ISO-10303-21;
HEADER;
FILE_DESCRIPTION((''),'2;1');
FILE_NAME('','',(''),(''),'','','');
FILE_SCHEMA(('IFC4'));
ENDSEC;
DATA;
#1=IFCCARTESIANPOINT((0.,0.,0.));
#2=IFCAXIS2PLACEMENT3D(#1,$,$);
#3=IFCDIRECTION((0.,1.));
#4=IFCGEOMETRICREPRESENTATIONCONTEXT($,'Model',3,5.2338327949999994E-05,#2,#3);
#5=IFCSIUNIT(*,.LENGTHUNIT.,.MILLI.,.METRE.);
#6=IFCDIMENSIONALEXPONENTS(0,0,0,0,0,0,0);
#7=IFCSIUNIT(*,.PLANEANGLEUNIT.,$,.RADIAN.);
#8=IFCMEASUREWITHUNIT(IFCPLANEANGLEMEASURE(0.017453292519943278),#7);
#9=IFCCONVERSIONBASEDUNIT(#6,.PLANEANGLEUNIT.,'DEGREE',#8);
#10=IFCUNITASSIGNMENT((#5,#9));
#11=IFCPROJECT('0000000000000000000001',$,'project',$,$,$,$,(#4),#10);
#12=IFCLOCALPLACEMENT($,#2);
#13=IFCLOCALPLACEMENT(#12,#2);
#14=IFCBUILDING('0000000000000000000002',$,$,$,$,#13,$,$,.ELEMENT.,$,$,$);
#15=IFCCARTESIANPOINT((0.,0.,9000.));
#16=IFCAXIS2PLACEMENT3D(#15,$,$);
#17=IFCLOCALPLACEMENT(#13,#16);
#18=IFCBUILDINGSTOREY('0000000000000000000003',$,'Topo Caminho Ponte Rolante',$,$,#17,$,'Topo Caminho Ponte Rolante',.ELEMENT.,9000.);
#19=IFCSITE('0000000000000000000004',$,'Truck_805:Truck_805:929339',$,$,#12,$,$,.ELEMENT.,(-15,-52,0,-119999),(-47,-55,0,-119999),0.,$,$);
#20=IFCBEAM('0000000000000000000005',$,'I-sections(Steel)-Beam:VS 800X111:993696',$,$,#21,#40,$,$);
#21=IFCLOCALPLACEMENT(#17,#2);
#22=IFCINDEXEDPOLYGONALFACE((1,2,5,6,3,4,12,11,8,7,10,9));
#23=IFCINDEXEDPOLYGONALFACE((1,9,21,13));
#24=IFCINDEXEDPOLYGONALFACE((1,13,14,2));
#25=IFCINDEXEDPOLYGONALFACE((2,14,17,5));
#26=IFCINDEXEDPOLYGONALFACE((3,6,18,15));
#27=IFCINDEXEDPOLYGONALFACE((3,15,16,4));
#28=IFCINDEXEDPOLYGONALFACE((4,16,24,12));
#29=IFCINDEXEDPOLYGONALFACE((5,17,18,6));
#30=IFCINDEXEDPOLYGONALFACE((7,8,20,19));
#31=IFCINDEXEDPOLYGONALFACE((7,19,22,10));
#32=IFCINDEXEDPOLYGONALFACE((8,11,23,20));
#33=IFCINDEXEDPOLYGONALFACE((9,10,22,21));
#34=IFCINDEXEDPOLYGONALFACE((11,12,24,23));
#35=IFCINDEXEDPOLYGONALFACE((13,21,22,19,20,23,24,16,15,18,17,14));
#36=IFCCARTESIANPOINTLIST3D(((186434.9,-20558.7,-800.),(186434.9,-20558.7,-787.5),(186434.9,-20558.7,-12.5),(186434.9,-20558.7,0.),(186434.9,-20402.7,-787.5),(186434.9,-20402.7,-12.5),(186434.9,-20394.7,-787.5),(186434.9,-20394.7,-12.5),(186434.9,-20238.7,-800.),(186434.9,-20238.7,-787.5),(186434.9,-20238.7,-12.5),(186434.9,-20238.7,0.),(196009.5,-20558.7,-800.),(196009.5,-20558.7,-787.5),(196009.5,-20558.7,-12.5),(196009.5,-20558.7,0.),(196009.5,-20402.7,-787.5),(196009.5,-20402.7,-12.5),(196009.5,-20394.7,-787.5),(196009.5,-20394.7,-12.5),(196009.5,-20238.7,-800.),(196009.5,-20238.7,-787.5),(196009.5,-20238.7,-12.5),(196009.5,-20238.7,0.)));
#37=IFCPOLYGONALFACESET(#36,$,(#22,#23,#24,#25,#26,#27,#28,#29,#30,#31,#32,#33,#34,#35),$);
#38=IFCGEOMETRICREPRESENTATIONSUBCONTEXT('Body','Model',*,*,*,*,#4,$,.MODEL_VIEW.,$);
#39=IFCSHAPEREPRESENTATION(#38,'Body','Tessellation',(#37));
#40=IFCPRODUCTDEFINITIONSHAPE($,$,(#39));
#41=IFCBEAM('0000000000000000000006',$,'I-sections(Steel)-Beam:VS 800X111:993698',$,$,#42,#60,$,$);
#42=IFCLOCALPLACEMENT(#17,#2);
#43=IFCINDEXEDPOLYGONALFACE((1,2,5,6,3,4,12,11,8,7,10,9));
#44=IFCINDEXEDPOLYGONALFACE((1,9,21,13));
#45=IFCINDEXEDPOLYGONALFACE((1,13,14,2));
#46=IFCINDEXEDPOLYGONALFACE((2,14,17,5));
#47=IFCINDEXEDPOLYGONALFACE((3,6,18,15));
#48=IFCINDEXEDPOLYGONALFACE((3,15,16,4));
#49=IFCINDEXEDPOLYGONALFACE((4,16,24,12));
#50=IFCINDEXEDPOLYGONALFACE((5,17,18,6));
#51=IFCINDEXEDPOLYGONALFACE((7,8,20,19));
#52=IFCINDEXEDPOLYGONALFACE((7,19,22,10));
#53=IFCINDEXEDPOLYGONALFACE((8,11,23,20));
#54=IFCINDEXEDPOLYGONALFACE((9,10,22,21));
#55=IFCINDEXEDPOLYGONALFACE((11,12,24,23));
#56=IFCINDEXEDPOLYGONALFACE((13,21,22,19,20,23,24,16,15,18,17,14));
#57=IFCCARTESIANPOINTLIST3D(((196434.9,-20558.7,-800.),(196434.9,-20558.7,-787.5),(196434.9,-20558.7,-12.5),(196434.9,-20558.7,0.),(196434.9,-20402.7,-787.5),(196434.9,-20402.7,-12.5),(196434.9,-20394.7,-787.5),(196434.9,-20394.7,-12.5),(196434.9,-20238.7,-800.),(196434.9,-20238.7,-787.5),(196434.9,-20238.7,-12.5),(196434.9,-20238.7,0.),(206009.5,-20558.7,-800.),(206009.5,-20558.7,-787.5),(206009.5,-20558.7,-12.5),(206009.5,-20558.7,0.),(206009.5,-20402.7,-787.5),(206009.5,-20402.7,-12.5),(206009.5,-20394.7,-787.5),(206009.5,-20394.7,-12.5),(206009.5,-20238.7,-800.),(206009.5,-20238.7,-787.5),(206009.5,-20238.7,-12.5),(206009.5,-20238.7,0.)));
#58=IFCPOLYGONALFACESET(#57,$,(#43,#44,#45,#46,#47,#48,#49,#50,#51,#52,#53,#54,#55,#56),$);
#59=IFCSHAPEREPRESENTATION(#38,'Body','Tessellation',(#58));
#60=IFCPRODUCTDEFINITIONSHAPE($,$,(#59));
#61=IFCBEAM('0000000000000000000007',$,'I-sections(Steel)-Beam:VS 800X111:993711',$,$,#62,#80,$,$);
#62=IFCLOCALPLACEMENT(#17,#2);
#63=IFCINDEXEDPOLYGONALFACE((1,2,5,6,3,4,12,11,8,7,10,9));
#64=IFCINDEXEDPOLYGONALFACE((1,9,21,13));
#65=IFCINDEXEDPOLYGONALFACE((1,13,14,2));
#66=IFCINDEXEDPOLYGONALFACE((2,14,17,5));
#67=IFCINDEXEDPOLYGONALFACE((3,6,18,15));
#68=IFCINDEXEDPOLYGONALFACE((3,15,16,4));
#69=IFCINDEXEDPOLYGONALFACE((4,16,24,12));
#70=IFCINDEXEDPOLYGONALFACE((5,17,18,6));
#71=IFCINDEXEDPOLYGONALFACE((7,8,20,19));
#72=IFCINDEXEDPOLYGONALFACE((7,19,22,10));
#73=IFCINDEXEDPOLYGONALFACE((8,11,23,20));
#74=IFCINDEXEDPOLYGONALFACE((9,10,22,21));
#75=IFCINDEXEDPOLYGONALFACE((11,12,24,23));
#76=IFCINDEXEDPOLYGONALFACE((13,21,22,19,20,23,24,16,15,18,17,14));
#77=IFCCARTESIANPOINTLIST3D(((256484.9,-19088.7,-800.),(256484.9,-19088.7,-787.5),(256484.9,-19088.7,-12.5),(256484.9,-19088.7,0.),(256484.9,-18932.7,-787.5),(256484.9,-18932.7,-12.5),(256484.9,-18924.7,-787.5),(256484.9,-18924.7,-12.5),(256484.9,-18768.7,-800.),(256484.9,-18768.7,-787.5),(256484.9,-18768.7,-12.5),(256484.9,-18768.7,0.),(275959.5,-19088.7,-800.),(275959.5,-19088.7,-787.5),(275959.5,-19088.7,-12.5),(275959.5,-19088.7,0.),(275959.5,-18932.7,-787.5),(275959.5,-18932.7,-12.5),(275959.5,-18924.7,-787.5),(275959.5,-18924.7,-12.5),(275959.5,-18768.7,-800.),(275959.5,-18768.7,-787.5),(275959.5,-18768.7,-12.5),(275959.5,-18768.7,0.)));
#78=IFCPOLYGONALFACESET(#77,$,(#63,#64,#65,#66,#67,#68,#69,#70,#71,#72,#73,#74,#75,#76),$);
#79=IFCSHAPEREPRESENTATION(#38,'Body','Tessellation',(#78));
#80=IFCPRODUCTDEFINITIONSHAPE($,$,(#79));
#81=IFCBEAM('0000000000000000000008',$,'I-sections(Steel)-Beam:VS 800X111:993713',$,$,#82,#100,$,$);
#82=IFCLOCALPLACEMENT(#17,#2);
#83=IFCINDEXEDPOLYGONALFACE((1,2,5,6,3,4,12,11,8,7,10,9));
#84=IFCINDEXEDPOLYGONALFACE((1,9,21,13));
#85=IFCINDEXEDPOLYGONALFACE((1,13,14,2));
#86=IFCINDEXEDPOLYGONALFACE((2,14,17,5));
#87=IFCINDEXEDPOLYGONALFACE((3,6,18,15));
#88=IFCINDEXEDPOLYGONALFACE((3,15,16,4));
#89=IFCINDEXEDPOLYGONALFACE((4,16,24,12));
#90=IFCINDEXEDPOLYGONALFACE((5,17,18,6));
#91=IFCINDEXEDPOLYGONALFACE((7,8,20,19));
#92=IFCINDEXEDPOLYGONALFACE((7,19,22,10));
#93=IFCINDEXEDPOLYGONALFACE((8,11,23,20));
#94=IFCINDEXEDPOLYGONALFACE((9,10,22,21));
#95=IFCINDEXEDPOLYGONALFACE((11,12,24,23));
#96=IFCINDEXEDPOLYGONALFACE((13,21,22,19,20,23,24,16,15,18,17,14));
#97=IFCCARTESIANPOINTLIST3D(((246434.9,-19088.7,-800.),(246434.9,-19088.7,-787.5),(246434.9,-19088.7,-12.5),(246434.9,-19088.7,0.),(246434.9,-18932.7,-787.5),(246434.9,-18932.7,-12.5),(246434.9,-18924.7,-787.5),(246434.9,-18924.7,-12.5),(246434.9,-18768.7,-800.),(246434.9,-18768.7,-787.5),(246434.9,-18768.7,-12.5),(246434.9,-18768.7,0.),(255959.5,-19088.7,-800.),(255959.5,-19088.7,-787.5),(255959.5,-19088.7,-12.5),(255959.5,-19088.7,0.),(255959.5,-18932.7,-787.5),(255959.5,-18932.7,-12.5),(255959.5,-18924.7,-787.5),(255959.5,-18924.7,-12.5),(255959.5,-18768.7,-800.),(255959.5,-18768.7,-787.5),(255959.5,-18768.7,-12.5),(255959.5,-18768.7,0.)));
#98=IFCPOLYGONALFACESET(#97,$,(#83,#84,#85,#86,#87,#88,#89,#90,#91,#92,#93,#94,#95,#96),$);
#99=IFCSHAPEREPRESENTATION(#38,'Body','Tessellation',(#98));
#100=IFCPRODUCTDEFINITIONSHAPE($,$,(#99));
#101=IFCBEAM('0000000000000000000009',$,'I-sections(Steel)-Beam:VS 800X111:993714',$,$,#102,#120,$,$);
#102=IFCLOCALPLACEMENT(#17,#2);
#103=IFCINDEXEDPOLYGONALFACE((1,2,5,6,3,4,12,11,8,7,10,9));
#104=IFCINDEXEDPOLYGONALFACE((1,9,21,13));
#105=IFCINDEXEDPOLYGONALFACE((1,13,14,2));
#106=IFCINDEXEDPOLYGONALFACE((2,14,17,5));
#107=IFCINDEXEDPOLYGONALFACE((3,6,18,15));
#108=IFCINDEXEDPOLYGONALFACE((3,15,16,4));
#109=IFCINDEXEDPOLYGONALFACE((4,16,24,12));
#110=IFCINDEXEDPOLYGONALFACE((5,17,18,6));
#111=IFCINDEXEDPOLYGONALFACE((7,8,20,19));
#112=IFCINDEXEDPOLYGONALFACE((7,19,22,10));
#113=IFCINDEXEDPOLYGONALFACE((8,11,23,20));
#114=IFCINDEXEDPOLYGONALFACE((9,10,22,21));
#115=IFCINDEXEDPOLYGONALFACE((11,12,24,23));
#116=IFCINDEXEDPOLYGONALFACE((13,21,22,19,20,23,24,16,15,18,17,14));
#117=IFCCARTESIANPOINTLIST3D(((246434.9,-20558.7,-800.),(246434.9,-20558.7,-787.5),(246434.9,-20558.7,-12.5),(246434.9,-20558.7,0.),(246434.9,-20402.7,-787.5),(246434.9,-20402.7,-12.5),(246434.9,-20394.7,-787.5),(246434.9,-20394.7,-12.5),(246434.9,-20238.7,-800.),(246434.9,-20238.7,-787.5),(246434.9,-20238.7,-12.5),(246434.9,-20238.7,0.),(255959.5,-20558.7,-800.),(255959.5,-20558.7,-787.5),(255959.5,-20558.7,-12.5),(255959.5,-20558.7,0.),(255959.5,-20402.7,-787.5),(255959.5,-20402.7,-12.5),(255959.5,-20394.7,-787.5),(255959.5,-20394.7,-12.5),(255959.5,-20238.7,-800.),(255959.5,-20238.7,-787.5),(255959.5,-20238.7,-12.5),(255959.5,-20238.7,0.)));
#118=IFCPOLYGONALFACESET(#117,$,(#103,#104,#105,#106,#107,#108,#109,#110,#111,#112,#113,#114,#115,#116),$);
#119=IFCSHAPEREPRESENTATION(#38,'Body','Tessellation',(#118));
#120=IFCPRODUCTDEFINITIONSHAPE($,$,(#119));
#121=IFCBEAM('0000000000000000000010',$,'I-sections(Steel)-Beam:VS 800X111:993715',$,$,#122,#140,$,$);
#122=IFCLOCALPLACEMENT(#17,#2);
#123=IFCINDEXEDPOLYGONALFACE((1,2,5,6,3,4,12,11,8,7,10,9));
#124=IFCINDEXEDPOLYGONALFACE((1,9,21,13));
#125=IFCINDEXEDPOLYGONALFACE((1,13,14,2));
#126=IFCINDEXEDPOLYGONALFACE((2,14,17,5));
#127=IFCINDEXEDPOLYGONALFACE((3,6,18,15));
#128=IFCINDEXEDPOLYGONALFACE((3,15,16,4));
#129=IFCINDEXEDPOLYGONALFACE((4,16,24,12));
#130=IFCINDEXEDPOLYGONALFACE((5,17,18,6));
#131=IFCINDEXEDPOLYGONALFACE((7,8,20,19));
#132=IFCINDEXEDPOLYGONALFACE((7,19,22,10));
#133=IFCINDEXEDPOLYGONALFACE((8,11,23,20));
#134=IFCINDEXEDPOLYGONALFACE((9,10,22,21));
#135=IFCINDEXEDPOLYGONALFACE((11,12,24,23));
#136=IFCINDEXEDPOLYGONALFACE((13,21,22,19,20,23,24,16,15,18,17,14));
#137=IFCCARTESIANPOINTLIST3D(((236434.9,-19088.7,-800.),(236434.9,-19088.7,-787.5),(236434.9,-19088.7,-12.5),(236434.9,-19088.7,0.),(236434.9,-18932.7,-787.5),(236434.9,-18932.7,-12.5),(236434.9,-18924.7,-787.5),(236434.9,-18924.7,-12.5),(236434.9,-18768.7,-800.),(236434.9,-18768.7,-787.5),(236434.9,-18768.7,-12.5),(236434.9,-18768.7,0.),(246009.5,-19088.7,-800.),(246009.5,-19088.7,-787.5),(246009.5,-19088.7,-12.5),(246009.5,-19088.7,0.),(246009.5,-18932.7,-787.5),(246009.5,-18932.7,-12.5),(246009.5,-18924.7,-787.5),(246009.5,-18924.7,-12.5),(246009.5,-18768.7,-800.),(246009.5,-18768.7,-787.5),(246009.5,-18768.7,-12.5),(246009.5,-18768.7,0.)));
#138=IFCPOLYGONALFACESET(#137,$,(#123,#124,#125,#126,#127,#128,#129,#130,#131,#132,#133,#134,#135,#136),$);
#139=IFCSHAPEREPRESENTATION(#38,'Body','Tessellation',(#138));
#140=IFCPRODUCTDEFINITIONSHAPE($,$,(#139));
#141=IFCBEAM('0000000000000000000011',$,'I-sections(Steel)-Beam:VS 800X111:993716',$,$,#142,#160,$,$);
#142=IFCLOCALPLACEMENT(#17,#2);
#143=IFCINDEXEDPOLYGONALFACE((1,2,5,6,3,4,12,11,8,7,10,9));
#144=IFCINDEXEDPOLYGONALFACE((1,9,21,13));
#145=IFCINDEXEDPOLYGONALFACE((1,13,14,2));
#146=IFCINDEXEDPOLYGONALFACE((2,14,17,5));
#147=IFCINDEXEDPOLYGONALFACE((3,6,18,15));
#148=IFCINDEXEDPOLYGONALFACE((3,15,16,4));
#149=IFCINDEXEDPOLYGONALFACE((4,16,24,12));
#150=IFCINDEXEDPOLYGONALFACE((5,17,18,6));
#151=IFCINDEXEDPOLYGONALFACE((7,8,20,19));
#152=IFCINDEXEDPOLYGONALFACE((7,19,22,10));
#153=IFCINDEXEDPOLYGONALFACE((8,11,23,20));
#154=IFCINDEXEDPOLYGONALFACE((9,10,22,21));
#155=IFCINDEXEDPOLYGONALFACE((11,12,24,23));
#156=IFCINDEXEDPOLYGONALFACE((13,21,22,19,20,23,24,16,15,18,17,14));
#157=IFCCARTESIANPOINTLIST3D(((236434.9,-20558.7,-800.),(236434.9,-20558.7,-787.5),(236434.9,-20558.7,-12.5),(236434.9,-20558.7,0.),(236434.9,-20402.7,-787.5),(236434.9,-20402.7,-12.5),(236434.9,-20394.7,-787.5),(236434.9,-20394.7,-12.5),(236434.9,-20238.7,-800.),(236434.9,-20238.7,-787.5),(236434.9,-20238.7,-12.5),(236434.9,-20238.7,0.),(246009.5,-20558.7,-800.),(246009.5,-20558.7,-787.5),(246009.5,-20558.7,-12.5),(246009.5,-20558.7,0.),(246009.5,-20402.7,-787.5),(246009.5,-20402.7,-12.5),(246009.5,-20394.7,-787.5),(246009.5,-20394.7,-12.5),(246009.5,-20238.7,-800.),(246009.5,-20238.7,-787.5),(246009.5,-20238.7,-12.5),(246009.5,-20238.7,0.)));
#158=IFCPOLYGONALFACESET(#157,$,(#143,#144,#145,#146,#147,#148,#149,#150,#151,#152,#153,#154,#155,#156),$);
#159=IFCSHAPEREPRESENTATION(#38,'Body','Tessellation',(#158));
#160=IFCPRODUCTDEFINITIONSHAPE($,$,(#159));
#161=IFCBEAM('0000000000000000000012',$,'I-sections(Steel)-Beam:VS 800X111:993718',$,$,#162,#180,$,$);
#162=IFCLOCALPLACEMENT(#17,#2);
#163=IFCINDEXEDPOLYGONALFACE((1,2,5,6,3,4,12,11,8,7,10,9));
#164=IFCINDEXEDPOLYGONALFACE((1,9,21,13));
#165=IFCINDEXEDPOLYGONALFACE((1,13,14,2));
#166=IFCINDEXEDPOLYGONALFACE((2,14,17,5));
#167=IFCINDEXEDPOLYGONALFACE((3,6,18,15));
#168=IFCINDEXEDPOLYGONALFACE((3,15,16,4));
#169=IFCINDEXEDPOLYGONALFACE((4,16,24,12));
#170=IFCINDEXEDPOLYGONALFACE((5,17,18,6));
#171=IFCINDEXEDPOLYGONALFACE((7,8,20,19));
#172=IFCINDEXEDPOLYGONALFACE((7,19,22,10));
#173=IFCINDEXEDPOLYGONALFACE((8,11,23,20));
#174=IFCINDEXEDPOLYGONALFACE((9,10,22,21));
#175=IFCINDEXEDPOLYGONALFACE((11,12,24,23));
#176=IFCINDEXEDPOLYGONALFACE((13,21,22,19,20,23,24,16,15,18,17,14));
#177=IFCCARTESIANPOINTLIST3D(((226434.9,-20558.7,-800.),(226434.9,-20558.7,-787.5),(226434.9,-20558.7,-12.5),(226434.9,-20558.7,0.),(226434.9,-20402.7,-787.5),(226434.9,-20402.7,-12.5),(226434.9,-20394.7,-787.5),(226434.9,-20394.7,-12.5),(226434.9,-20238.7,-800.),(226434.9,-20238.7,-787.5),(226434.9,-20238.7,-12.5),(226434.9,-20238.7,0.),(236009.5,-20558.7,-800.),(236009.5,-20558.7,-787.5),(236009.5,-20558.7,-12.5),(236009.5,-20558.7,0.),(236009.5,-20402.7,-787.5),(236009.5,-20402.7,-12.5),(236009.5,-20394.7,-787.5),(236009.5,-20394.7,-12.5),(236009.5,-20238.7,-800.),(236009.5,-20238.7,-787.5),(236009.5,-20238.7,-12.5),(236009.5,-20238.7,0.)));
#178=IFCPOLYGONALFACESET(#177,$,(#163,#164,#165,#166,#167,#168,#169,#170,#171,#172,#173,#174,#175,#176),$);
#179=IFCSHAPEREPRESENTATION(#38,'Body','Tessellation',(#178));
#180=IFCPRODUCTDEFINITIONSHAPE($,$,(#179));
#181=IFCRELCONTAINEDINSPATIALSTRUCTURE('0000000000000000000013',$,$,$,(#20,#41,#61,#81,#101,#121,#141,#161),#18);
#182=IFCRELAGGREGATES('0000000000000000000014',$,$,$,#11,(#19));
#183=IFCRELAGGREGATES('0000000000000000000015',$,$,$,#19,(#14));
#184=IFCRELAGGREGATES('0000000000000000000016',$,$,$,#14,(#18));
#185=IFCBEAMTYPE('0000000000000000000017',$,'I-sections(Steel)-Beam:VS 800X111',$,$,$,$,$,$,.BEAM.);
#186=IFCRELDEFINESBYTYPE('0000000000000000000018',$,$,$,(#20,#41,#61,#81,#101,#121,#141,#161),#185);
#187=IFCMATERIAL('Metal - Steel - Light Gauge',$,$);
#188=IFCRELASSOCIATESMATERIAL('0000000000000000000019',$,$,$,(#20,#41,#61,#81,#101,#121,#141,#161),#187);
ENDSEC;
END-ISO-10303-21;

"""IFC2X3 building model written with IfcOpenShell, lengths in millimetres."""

from ifc_helpers import new_model, entity, si_unit, converted_unit, direction, frame, frame_2d, origin, place, context, subcontext, project, spatial, polyline, i_section, outline, extrude, material, type_object, element, save


model = new_model("IFC2X3")

# Units and contexts
model_context = context("Model", 3, precision=5.2338327949999994e-05, world=origin(), true_north=direction((0.0, 1.0)))
body_context = subcontext(model_context, "Body", "Model", "MODEL_VIEW")
ifc_project = project(units=[si_unit("LENGTHUNIT", "METRE", prefix="MILLI"), converted_unit("PLANEANGLEUNIT", "DEGREE", entity("IfcPlaneAngleMeasure", 0.017453292519943278), si_unit("PLANEANGLEUNIT", "RADIAN"), dimensions=[0, 0, 0, 0, 0, 0, 0])], contexts=[model_context])

# Site, building, storey
site_placement = place(None, origin())
site = spatial("IfcSite", under=ifc_project, at=site_placement, Name="Truck_805:Truck_805:929339", CompositionType="ELEMENT", RefLatitude=(-15, -52, 0, -119999), RefLongitude=(-47, -55, 0, -119999), RefElevation=0.0)
building_placement = place(site_placement, origin())
building = spatial("IfcBuilding", under=site, at=building_placement, CompositionType="ELEMENT")
storey_placement = place(building_placement, frame((0.0, 0.0, 9000.0)))
storey = spatial("IfcBuildingStorey", under=building, at=storey_placement, Name="Topo Caminho Ponte Rolante", LongName="Topo Caminho Ponte Rolante", CompositionType="ELEMENT", Elevation=9000.0)

# Beams
ifc_material = material(Name="Metal - Steel - Light Gauge")
beam_type_1 = type_object("IfcBeamType", Name="I-sections(Steel)-Beam:VS 800X111", PredefinedType="BEAM")
beam_1_placement = place(storey_placement, frame((186222.2, -20398.7, 0.0)))
element("IfcBeam", 1, at=beam_1_placement, inside=storey, type_object=beam_type_1, material=ifc_material, Name="I-sections(Steel)-Beam:VS 800X111:993696", context=body_context, shape_type="SweptSolid", body=[
    extrude(outline(polyline([(387.5, -160.0), (400.0, -160.0), (400.0, 160.0), (387.5, 160.0), (387.5, 4.0), (-387.5, 4.0), (-387.5, 160.0), (-400.0, 160.0), (-400.0, -160.0), (-387.5, -160.0), (-387.5, -4.0), (387.5, -4.0), (387.5, -160.0)])), frame((212.7, 0.0, -400.0), z_axis=(1.0, 0.0, 0.0), x_axis=(0.0, 0.0, -1.0)), (0.0, 0.0, 1.0), 9574.6),
])
beam_2_placement = place(storey_placement, frame((196222.2, -20398.7, 0.0)))
element("IfcBeam", 2, at=beam_2_placement, inside=storey, type_object=beam_type_1, material=ifc_material, Name="I-sections(Steel)-Beam:VS 800X111:993698", context=body_context, shape_type="SweptSolid", body=[
    extrude(outline(polyline([(387.5, -160.0), (400.0, -160.0), (400.0, 160.0), (387.5, 160.0), (387.5, 4.0), (-387.5, 4.0), (-387.5, 160.0), (-400.0, 160.0), (-400.0, -160.0), (-387.5, -160.0), (-387.5, -4.0), (387.5, -4.0), (387.5, -160.0)])), frame((212.7, 0.0, -400.0), z_axis=(1.0, 0.0, 0.0), x_axis=(0.0, 0.0, -1.0)), (0.0, 0.0, 1.0), 9574.6),
])
beam_3_placement = place(storey_placement, frame((256222.2, -18928.7, 0.0)))
element("IfcBeam", 3, at=beam_3_placement, inside=storey, type_object=beam_type_1, material=ifc_material, Name="I-sections(Steel)-Beam:VS 800X111:993711", context=body_context, shape_type="SweptSolid", body=[
    extrude(i_section(OverallWidth=320.0, OverallDepth=800.0, WebThickness=8.0, FlangeThickness=12.5, at=frame_2d((0.0, 0.0), x_axis=(0.0, 1.0))), frame((262.7, 0.0, -400.0), z_axis=(1.0, 0.0, 0.0), x_axis=(0.0, 0.0, -1.0)), (0.0, 0.0, 1.0), 19474.6),
])
beam_4_placement = place(storey_placement, frame((246222.2, -18928.7, 0.0)))
element("IfcBeam", 4, at=beam_4_placement, inside=storey, type_object=beam_type_1, material=ifc_material, Name="I-sections(Steel)-Beam:VS 800X111:993713", context=body_context, shape_type="SweptSolid", body=[
    extrude(i_section(OverallWidth=320.0, OverallDepth=800.0, WebThickness=8.0, FlangeThickness=12.5, at=frame_2d((0.0, 0.0), x_axis=(0.0, 1.0))), frame((212.7, 0.0, -400.0), z_axis=(1.0, 0.0, 0.0), x_axis=(0.0, 0.0, -1.0)), (0.0, 0.0, 1.0), 9524.6),
])
beam_5_placement = place(storey_placement, frame((246222.2, -20398.7, 0.0)))
element("IfcBeam", 5, at=beam_5_placement, inside=storey, type_object=beam_type_1, material=ifc_material, Name="I-sections(Steel)-Beam:VS 800X111:993714", context=body_context, shape_type="SweptSolid", body=[
    extrude(outline(polyline([(387.5, -160.0), (400.0, -160.0), (400.0, 160.0), (387.5, 160.0), (387.5, 4.0), (-387.5, 4.0), (-387.5, 160.0), (-400.0, 160.0), (-400.0, -160.0), (-387.5, -160.0), (-387.5, -4.0), (387.5, -4.0), (387.5, -160.0)])), frame((212.7, 0.0, -400.0), z_axis=(1.0, 0.0, 0.0), x_axis=(0.0, 0.0, -1.0)), (0.0, 0.0, 1.0), 9524.6),
])
beam_6_placement = place(storey_placement, frame((236222.2, -18928.7, 0.0)))
element("IfcBeam", 6, at=beam_6_placement, inside=storey, type_object=beam_type_1, material=ifc_material, Name="I-sections(Steel)-Beam:VS 800X111:993715", context=body_context, shape_type="SweptSolid", body=[
    extrude(i_section(OverallWidth=320.0, OverallDepth=800.0, WebThickness=8.0, FlangeThickness=12.5, at=frame_2d((0.0, 0.0), x_axis=(0.0, 1.0))), frame((212.7, 0.0, -400.0), z_axis=(1.0, 0.0, 0.0), x_axis=(0.0, 0.0, -1.0)), (0.0, 0.0, 1.0), 9574.6),
])
beam_7_placement = place(storey_placement, frame((236222.2, -20398.7, 0.0)))
element("IfcBeam", 7, at=beam_7_placement, inside=storey, type_object=beam_type_1, material=ifc_material, Name="I-sections(Steel)-Beam:VS 800X111:993716", context=body_context, shape_type="SweptSolid", body=[
    extrude(outline(polyline([(387.5, -160.0), (400.0, -160.0), (400.0, 160.0), (387.5, 160.0), (387.5, 4.0), (-387.5, 4.0), (-387.5, 160.0), (-400.0, 160.0), (-400.0, -160.0), (-387.5, -160.0), (-387.5, -4.0), (387.5, -4.0), (387.5, -160.0)])), frame((212.7, 0.0, -400.0), z_axis=(1.0, 0.0, 0.0), x_axis=(0.0, 0.0, -1.0)), (0.0, 0.0, 1.0), 9574.6),
])
beam_8_placement = place(storey_placement, frame((226222.2, -20398.7, 0.0)))
element("IfcBeam", 8, at=beam_8_placement, inside=storey, type_object=beam_type_1, material=ifc_material, Name="I-sections(Steel)-Beam:VS 800X111:993718", context=body_context, shape_type="SweptSolid", body=[
    extrude(outline(polyline([(387.5, -160.0), (400.0, -160.0), (400.0, 160.0), (387.5, 160.0), (387.5, 4.0), (-387.5, 4.0), (-387.5, 160.0), (-400.0, 160.0), (-400.0, -160.0), (-387.5, -160.0), (-387.5, -4.0), (387.5, -4.0), (387.5, -160.0)])), frame((212.7, 0.0, -400.0), z_axis=(1.0, 0.0, 0.0), x_axis=(0.0, 0.0, -1.0)), (0.0, 0.0, 1.0), 9574.6),
])

save(model, "model.ifc")
